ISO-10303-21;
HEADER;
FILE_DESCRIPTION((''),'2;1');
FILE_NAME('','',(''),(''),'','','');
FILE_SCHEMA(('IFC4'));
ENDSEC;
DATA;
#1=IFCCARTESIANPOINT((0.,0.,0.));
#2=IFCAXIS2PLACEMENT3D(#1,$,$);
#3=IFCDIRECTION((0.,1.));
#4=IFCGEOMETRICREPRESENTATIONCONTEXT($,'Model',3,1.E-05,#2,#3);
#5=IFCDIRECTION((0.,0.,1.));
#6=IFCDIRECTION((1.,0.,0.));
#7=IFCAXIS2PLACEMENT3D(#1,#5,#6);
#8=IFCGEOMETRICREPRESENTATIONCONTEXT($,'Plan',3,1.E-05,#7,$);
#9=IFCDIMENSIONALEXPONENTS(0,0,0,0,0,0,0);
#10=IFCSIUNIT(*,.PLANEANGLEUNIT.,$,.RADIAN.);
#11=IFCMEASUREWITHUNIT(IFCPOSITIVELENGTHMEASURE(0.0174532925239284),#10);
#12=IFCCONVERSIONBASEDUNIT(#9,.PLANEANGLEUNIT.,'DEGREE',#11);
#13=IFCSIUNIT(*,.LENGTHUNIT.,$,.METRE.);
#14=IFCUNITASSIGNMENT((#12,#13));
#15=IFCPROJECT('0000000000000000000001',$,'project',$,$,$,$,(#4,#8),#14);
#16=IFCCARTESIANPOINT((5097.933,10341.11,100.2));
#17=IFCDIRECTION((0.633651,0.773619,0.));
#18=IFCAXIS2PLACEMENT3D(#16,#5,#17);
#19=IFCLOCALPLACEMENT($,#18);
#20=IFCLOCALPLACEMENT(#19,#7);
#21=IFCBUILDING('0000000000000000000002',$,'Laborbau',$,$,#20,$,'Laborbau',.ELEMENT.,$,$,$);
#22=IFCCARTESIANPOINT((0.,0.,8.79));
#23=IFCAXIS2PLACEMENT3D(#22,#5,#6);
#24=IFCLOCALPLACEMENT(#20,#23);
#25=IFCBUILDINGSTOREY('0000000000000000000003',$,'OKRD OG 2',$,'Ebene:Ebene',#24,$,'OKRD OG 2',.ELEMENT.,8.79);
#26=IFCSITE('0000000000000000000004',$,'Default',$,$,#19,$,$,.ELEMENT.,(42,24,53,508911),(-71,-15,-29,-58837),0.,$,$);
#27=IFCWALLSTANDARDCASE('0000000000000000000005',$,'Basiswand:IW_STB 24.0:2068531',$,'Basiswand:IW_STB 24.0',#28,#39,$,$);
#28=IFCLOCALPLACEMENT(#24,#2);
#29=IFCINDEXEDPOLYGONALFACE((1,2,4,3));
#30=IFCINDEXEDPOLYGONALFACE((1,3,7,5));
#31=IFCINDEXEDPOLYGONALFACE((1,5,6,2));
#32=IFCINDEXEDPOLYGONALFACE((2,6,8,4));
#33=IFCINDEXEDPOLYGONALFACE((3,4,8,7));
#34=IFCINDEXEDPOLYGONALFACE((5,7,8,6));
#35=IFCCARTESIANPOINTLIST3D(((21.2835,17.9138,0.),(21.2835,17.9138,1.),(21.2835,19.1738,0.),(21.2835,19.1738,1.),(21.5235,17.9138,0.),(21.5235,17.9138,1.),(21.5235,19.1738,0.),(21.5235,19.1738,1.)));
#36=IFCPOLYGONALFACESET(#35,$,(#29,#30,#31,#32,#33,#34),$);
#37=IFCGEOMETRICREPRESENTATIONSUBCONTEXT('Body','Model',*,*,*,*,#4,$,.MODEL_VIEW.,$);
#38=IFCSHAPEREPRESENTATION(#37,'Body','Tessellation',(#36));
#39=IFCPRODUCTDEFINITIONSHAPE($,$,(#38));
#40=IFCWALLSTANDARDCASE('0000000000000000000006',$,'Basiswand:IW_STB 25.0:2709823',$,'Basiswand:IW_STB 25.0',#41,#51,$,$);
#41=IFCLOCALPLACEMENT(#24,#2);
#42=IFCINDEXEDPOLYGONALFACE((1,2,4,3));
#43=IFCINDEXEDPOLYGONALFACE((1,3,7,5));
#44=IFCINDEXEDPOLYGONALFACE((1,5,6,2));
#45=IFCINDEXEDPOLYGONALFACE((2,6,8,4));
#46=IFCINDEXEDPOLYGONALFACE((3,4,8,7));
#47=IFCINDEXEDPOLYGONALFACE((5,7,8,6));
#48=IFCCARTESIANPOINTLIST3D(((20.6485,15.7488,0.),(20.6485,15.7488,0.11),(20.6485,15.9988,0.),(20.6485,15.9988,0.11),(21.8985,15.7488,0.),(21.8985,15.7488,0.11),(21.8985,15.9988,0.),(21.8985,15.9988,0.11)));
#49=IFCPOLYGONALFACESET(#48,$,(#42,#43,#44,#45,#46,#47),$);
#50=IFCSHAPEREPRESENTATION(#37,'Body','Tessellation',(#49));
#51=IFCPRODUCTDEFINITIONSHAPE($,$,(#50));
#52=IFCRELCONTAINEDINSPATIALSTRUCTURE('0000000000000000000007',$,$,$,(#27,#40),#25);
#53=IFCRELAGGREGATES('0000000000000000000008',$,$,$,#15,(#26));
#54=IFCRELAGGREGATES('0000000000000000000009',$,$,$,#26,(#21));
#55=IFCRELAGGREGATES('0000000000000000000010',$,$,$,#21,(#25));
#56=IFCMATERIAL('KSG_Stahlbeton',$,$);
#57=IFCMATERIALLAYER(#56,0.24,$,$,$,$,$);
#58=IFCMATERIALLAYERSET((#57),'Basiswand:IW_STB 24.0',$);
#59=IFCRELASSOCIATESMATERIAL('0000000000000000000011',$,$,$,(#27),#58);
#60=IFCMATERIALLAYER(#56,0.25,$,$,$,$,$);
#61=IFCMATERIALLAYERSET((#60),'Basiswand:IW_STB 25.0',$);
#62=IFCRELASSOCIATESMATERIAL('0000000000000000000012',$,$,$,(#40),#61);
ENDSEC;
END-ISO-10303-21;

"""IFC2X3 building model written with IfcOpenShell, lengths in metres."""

from ifc_helpers import new_model, entity, si_unit, converted_unit, direction, frame, frame_2d, origin, origin_with_axes, place, context, subcontext, project, spatial, rectangle, extrude, material, layer, layer_set, layer_usage, element, save


model = new_model("IFC2X3")

# Units and contexts
model_context = context("Model", 3, precision=1e-05, world=origin(), true_north=direction((0.0, 1.0)))
plan_context = context("Plan", 3, precision=1e-05, world=origin_with_axes())
body_context = subcontext(model_context, "Body", "Model", "MODEL_VIEW")
ifc_project = project(units=[converted_unit("PLANEANGLEUNIT", "DEGREE", entity("IfcPositiveLengthMeasure", 0.0174532925239284), si_unit("PLANEANGLEUNIT", "RADIAN"), dimensions=[0, 0, 0, 0, 0, 0, 0]), si_unit("LENGTHUNIT", "METRE")], contexts=[model_context, plan_context])

# Site, building, storey
site_placement = place(None, frame((5097.933, 10341.11, 100.2), z_axis=(0.0, 0.0, 1.0), x_axis=(0.633651, 0.773619, 0.0)))
site = spatial("IfcSite", under=ifc_project, at=site_placement, Name="Default", CompositionType="ELEMENT", RefLatitude=(42, 24, 53, 508911), RefLongitude=(-71, -15, -29, -58837), RefElevation=0.0)
building_placement = place(site_placement, origin_with_axes())
building = spatial("IfcBuilding", under=site, at=building_placement, Name="Laborbau", LongName="Laborbau", CompositionType="ELEMENT")
storey_placement = place(building_placement, frame((0.0, 0.0, 8.79), z_axis=(0.0, 0.0, 1.0), x_axis=(1.0, 0.0, 0.0)))
storey = spatial("IfcBuildingStorey", under=building, at=storey_placement, Name="OKRD OG 2", ObjectType="Ebene:Ebene", LongName="OKRD OG 2", CompositionType="ELEMENT", Elevation=8.79)

# Shared definitions
ifc_material_1 = material(Name="KSG_Stahlbeton")
ifc_layer_1 = layer(ifc_material_1, 0.25)
ifc_layer_set_1 = layer_set([ifc_layer_1], Name="Basiswand:IW_STB 25.0")

# Walls
ifc_layer_2 = layer(ifc_material_1, 0.24)
ifc_layer_set_2 = layer_set([ifc_layer_2], Name="Basiswand:IW_STB 24.0")
ifc_layer_usage_1 = layer_usage(ifc_layer_set_2, "AXIS2", "NEGATIVE", 0.12)
wall_1_placement = place(storey_placement, frame((21.4035, 17.9138, 0.0), z_axis=(0.0, 0.0, 1.0), x_axis=(0.0, 1.0, 0.0)))
element("IfcWallStandardCase", 1, at=wall_1_placement, inside=storey, material=ifc_layer_usage_1, Name="Basiswand:IW_STB 24.0:2068531", ObjectType="Basiswand:IW_STB 24.0", context=body_context, shape_type="SweptSolid", body=[
    extrude(rectangle(XDim=1.26, YDim=0.24, at=frame_2d((0.63, 0.0), x_axis=(-1.0, 0.0))), origin(), (0.0, 0.0, 1.0), 1.0),
])
ifc_layer_usage_2 = layer_usage(ifc_layer_set_1, "AXIS2", "NEGATIVE", 0.125)
wall_2_placement = place(storey_placement, frame((20.6485, 15.8738, 0.0), z_axis=(0.0, 0.0, 1.0), x_axis=(1.0, 0.0, 0.0)))
element("IfcWallStandardCase", 2, at=wall_2_placement, inside=storey, material=ifc_layer_usage_2, Name="Basiswand:IW_STB 25.0:2709823", ObjectType="Basiswand:IW_STB 25.0", context=body_context, shape_type="SweptSolid", body=[
    extrude(rectangle(XDim=1.25, YDim=0.25, at=frame_2d((0.625, 0.0), x_axis=(-1.0, 0.0))), origin(), (0.0, 0.0, 1.0), 0.11),
])

save(model, "model.ifc")
